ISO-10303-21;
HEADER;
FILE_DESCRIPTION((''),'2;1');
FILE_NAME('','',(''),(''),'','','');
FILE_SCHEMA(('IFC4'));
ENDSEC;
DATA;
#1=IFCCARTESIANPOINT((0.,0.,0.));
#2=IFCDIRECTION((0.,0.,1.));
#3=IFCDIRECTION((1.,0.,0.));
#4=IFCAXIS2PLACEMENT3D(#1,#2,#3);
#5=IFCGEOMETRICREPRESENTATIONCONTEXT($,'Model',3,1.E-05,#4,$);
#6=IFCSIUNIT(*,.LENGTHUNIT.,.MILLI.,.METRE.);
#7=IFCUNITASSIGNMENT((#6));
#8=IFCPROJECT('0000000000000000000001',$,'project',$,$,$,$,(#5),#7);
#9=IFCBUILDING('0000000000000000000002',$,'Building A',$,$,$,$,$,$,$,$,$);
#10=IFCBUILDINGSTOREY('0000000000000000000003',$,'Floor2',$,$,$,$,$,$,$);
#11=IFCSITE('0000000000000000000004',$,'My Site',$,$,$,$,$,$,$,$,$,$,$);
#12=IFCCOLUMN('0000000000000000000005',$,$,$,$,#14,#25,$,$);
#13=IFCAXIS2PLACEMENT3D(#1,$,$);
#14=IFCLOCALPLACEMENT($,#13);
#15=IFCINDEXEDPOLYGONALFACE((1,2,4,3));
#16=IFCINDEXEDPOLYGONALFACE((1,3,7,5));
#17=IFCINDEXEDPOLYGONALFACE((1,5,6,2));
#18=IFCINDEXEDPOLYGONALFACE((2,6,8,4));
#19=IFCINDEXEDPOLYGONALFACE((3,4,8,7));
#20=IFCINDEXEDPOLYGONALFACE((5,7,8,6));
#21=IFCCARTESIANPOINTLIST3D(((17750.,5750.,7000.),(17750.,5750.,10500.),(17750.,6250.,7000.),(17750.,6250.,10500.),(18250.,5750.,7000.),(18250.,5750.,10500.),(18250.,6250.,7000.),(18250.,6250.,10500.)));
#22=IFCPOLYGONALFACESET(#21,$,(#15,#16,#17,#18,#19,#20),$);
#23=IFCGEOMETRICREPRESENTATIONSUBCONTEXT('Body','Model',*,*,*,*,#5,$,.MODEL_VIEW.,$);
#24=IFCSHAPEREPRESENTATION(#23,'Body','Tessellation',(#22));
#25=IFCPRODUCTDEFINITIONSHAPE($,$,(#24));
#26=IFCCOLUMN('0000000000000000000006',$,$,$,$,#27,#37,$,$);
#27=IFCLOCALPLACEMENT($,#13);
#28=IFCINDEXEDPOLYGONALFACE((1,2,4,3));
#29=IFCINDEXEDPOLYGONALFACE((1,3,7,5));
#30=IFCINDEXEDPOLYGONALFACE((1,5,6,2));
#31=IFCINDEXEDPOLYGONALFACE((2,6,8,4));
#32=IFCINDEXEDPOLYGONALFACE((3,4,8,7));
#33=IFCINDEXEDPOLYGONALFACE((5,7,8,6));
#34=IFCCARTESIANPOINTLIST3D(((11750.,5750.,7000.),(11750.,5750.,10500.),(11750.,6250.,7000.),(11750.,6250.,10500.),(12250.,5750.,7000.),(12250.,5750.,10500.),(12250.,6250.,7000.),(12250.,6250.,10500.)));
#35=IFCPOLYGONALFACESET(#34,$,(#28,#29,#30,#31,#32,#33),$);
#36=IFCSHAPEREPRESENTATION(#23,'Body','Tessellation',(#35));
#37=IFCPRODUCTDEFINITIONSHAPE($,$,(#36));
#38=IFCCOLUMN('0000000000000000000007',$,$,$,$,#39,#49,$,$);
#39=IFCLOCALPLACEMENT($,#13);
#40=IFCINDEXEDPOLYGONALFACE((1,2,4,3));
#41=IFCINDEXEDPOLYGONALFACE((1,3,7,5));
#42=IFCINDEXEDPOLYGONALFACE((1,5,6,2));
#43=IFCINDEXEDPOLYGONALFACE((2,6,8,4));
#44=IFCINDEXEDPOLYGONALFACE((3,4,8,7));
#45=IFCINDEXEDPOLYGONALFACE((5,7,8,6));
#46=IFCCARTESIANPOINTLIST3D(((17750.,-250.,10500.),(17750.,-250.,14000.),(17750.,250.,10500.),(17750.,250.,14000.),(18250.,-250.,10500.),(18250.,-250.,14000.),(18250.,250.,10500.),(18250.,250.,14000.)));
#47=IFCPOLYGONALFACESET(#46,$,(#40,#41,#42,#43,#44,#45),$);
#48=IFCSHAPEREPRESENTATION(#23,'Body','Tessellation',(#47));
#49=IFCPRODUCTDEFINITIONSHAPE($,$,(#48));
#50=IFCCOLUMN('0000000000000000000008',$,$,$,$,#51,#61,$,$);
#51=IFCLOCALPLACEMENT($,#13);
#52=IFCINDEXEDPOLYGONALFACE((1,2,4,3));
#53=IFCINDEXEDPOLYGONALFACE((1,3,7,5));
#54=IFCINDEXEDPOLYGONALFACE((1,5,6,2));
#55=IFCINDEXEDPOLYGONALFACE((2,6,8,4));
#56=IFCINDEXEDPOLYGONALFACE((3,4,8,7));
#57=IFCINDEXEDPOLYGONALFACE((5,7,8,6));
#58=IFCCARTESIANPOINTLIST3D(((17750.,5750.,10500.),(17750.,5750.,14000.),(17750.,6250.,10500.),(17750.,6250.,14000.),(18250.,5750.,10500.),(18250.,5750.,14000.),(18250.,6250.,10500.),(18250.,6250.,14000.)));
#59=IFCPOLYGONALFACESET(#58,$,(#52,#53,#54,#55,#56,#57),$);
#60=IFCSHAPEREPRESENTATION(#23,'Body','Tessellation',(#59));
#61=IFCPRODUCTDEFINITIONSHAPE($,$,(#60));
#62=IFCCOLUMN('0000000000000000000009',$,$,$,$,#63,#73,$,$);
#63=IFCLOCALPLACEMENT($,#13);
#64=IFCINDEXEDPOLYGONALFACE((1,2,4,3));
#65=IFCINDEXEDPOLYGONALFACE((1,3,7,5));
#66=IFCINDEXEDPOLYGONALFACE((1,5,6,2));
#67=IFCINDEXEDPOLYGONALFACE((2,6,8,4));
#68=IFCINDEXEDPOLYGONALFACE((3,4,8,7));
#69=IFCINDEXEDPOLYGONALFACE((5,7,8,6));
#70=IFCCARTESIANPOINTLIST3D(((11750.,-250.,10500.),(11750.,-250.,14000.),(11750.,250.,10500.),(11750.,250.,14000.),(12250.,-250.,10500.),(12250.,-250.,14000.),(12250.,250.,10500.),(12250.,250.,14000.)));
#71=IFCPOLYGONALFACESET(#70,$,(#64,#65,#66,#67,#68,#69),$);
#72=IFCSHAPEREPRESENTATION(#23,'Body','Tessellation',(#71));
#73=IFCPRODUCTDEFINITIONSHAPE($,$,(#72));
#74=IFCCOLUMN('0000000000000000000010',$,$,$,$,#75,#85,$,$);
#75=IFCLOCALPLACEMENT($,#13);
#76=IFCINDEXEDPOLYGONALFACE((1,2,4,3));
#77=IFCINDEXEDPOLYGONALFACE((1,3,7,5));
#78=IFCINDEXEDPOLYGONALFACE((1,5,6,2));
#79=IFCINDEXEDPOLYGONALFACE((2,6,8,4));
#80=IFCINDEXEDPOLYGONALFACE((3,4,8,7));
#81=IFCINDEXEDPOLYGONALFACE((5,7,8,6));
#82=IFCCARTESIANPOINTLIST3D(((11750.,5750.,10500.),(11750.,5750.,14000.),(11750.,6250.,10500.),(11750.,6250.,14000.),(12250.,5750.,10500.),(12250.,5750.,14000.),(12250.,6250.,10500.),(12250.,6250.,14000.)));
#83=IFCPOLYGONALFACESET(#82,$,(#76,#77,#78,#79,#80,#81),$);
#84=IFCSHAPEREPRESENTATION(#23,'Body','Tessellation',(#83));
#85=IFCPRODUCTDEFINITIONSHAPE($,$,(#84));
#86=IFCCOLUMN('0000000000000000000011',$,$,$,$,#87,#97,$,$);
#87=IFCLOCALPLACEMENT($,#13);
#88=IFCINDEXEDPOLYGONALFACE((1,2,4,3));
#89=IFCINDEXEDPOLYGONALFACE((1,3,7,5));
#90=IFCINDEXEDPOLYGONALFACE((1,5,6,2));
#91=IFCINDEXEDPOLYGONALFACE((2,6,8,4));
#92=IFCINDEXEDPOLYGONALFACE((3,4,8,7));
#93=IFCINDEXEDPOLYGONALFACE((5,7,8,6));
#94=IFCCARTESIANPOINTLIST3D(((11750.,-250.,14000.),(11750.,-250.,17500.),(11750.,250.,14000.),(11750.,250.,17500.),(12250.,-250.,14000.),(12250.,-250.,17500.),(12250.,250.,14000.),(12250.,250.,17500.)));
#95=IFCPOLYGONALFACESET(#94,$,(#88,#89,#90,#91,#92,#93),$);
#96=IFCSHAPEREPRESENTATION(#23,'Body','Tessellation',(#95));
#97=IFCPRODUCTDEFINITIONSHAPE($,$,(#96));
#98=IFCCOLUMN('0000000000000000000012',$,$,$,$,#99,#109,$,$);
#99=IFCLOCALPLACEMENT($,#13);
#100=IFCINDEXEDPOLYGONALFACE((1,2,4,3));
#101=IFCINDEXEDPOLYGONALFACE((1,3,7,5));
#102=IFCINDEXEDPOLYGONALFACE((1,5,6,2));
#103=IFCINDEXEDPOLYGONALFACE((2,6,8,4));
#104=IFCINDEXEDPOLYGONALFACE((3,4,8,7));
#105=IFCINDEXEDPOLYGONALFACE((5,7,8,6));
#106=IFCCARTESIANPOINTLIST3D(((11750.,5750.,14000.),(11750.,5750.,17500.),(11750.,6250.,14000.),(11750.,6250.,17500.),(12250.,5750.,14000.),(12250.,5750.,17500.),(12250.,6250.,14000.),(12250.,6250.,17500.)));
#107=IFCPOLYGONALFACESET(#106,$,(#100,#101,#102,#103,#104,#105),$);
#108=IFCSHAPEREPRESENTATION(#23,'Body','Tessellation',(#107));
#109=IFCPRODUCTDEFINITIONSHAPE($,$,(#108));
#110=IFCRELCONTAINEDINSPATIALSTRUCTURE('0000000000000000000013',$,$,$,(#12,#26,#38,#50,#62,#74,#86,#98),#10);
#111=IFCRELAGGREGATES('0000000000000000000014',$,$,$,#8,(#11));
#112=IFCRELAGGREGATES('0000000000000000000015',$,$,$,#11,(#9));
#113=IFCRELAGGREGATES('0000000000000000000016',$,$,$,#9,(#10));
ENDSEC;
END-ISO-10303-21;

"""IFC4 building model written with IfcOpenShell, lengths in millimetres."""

from ifc_helpers import new_model, si_unit, frame, origin_with_axes, place, context, subcontext, project, spatial, line, indexed_curve, outline, extrude, element, save


model = new_model("IFC4")

# Units and contexts
model_context = context("Model", 3, precision=1e-05, world=origin_with_axes())
body_context = subcontext(model_context, "Body", "Model", "MODEL_VIEW")
ifc_project = project(units=[si_unit("LENGTHUNIT", "METRE", prefix="MILLI")], contexts=[model_context])

# Site, building, storey
site = spatial("IfcSite", under=ifc_project, Name="My Site")
building = spatial("IfcBuilding", under=site, Name="Building A")
storey = spatial("IfcBuildingStorey", under=building, Name="Floor2")

# Columns
for number, where, z_axis, x_axis in (
    (1, (18000.0, 6000.0, 7000.0), (0.0, 0.0, 1.0), (1.0, 0.0, 0.0)),
    (2, (12000.0, 6000.0, 7000.0), (0.0, 0.0, 1.0), (1.0, 0.0, 0.0)),
    (3, (18000.0, 0.0, 10500.0), (0.0, 0.0, 1.0), (1.0, 0.0, 0.0)),
    (4, (18000.0, 6000.0, 10500.0), (0.0, 0.0, 1.0), (1.0, 0.0, 0.0)),
    (5, (12000.0, 0.0, 10500.0), (0.0, 0.0, 1.0), (1.0, 0.0, 0.0)),
    (6, (12000.0, 6000.0, 10500.0), (0.0, 0.0, 1.0), (1.0, 0.0, 0.0)),
    (7, (12000.0, 0.0, 14000.0), (0.0, 0.0, 1.0), (1.0, 0.0, 0.0)),
    (8, (12000.0, 6000.0, 14000.0), (0.0, 0.0, 1.0), (1.0, 0.0, 0.0)),
):
    element("IfcColumn", number, at=place(None, frame(where, z_axis=z_axis, x_axis=x_axis)), inside=storey, context=body_context, shape_type="SweptSolid", body=[
        extrude(outline(indexed_curve([(-250.0, -250.0), (250.0, -250.0), (250.0, 250.0), (-250.0, 250.0)], segments=[line(1, 2, 3, 4, 1)])), origin_with_axes(), (0.0, 0.0, 1.0), 3500.0),
    ])

save(model, "model.ifc")
